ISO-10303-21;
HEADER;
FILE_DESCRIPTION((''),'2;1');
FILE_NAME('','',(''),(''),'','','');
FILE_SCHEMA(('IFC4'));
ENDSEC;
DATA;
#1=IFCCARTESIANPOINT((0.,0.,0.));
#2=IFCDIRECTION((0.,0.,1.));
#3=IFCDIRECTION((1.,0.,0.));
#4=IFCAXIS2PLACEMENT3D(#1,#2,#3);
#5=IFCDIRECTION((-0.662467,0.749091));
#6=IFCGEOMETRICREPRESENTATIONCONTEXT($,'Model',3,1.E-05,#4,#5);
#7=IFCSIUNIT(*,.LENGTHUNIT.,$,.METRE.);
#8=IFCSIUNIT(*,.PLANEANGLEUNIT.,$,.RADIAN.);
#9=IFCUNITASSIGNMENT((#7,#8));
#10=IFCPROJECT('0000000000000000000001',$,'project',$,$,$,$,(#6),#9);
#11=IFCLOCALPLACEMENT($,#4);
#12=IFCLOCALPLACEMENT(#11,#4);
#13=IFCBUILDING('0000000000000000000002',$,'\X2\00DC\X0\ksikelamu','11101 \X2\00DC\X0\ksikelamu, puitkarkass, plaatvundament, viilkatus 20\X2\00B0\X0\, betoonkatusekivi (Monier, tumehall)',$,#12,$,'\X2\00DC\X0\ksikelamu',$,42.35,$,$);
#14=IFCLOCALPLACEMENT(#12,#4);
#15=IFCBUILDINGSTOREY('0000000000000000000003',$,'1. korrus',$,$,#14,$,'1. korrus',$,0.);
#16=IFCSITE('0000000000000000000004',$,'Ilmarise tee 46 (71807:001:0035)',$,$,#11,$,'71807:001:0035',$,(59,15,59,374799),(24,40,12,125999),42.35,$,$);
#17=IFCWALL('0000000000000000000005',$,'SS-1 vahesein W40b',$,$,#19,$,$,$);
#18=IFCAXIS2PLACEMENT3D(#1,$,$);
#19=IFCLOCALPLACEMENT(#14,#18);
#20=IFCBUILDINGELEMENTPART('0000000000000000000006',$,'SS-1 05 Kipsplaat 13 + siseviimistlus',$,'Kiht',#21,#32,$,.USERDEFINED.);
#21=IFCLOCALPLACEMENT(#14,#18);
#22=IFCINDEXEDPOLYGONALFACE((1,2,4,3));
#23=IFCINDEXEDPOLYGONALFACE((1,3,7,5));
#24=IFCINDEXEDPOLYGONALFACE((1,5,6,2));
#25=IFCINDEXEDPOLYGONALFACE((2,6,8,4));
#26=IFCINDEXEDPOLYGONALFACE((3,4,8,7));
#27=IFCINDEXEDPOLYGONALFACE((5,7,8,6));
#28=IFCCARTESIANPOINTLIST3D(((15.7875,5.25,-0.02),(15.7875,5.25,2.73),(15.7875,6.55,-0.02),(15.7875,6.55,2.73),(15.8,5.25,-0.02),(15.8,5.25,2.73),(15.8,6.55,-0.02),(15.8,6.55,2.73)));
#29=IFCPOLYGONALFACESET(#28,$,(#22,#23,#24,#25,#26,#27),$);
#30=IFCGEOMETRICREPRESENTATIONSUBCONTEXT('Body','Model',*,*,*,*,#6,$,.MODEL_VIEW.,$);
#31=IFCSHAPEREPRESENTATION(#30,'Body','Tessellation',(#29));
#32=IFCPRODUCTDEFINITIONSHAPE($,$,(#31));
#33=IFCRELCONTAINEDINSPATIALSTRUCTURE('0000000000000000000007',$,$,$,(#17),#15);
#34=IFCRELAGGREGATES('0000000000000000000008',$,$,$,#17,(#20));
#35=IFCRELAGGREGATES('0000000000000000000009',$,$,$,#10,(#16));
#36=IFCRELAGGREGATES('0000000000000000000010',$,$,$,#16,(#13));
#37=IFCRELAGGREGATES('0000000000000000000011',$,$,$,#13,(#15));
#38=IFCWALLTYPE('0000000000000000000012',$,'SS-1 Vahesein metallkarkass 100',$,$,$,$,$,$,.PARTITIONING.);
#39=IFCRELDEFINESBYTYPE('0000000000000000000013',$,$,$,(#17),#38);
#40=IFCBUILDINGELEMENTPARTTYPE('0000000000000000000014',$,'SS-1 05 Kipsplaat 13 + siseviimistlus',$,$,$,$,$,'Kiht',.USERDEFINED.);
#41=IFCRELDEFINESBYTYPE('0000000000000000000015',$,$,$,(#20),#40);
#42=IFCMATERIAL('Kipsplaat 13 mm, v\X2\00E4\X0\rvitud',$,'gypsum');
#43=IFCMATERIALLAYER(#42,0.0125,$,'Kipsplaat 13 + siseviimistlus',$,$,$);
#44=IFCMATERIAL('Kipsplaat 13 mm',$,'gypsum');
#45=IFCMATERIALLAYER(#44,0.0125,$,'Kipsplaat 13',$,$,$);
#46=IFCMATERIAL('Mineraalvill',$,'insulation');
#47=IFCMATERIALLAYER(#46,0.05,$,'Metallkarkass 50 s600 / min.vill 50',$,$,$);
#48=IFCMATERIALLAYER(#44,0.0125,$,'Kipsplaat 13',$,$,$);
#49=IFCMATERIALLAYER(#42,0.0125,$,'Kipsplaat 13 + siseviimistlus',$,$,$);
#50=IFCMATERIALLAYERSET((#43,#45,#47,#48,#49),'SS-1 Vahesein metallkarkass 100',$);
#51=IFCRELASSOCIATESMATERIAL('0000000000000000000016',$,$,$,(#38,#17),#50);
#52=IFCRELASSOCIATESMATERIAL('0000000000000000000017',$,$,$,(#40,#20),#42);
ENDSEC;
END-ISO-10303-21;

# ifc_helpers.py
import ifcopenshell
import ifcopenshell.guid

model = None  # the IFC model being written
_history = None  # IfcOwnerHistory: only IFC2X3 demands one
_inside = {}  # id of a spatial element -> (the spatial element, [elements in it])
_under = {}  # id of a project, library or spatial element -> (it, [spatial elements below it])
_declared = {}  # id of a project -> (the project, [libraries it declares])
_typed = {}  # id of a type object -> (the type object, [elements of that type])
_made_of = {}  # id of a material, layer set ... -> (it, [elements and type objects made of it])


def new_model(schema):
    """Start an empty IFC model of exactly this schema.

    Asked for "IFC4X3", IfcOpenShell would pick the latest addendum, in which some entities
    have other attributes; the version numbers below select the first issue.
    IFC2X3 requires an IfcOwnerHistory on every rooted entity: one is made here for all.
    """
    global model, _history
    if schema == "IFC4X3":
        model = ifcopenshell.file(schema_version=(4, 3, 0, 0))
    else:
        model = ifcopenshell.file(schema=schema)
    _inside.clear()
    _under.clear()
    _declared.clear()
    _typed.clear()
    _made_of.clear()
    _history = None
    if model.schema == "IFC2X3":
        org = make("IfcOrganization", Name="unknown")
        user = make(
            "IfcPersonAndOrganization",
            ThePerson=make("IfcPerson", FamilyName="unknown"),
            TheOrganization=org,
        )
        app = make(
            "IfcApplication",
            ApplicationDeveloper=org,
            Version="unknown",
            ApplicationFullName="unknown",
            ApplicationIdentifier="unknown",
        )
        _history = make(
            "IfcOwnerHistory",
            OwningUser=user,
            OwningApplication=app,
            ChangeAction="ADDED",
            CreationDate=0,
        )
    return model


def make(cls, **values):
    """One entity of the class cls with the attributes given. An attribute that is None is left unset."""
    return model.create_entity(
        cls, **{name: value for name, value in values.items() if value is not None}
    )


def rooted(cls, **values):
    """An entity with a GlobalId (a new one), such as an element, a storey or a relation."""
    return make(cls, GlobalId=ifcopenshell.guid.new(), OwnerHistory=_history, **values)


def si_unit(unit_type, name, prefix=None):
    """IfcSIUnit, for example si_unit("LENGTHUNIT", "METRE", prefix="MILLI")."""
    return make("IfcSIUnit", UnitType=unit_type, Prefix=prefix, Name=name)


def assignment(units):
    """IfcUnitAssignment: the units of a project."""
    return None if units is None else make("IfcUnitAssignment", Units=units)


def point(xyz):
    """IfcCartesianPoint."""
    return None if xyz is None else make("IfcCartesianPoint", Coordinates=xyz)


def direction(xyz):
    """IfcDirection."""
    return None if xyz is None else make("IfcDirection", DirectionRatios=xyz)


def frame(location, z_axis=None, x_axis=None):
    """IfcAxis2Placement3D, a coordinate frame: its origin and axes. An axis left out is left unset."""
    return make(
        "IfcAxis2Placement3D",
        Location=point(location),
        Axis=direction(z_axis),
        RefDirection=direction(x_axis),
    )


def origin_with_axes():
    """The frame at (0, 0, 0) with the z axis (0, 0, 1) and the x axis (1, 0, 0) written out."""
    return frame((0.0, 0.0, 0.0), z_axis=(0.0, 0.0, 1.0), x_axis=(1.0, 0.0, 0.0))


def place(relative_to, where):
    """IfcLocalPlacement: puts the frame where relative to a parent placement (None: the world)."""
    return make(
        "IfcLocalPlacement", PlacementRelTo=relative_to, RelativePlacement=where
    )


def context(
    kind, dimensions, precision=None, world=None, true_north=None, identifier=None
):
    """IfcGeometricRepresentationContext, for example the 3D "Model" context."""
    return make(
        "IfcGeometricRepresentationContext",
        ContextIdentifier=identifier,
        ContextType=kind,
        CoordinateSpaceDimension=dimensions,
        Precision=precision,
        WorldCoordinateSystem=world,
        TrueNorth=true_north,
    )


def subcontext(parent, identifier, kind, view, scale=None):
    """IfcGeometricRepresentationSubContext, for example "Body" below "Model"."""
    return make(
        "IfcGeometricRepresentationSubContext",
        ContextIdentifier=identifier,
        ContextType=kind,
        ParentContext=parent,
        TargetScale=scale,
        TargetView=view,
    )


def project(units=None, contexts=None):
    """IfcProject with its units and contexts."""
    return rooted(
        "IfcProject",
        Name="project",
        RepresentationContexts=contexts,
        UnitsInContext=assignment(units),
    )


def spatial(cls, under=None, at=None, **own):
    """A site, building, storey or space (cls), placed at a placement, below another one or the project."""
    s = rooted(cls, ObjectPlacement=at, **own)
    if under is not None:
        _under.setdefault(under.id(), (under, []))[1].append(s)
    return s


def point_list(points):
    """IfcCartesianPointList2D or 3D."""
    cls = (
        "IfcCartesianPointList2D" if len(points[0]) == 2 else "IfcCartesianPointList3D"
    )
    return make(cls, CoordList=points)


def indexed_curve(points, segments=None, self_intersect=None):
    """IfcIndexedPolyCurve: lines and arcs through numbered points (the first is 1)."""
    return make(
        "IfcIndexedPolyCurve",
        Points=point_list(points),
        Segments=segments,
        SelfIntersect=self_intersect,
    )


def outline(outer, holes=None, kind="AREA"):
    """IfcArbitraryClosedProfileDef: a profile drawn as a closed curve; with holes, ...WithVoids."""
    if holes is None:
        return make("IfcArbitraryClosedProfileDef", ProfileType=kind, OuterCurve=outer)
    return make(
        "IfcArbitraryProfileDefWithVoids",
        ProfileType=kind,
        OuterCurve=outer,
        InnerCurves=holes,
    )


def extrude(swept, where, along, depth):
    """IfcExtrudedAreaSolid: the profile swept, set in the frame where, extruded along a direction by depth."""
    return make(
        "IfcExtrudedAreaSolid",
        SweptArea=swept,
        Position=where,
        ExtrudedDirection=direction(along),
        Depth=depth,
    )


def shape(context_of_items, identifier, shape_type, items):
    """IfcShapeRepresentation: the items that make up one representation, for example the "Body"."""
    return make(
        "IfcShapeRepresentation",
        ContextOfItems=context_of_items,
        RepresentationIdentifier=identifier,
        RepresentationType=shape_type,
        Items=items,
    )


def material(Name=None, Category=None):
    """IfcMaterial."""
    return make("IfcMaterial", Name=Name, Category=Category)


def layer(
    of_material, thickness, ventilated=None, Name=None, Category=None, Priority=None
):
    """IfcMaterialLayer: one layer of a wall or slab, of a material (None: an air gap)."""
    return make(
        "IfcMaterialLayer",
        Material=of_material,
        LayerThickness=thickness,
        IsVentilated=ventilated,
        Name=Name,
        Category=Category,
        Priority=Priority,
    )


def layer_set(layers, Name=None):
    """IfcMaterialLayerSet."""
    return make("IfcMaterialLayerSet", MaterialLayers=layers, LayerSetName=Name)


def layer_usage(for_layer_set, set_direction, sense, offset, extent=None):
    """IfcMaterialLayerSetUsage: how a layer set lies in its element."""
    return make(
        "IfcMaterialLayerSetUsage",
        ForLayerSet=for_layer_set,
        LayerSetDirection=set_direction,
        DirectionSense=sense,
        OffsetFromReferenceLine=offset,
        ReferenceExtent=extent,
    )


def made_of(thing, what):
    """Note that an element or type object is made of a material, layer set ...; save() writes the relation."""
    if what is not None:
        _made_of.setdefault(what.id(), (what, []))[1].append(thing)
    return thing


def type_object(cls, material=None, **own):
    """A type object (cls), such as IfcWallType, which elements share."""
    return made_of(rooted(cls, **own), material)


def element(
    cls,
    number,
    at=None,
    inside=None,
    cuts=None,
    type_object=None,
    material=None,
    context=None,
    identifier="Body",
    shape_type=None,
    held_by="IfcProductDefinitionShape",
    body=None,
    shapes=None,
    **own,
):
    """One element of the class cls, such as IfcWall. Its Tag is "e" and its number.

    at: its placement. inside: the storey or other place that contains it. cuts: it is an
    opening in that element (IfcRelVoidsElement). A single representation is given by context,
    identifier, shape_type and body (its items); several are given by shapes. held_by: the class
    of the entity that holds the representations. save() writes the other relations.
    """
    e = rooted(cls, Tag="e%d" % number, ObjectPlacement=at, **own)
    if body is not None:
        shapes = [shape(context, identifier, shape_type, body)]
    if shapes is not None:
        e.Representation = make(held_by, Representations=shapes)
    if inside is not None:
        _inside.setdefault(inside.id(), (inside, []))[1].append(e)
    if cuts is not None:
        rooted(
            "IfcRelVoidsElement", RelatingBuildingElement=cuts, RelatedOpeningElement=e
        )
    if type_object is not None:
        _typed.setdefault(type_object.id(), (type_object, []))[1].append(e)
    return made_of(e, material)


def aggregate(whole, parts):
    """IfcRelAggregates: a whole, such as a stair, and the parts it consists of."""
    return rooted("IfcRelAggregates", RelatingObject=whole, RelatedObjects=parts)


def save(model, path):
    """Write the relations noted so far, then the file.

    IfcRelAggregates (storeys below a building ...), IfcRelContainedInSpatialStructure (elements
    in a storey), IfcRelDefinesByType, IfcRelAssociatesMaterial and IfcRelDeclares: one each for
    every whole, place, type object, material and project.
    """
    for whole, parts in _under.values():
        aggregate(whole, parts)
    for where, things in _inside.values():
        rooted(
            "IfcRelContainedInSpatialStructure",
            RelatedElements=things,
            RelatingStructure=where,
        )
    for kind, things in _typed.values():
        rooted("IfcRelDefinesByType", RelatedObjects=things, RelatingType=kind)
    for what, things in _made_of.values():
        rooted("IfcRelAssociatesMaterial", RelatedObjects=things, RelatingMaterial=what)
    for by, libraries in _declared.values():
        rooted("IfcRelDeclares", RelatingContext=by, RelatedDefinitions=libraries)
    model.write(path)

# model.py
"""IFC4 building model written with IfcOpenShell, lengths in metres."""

from ifc_helpers import new_model, si_unit, direction, frame, origin_with_axes, place, context, subcontext, project, spatial, indexed_curve, outline, extrude, material, layer, layer_set, layer_usage, type_object, element, aggregate, save


model = new_model("IFC4")

# Units and contexts
model_context = context("Model", 3, precision=1e-05, world=origin_with_axes(), true_north=direction((-0.662467, 0.749091)))
body_context = subcontext(model_context, "Body", "Model", "MODEL_VIEW")
ifc_project = project(units=[si_unit("LENGTHUNIT", "METRE"), si_unit("PLANEANGLEUNIT", "RADIAN")], contexts=[model_context])

# Site, building, storey
site_placement = place(None, origin_with_axes())
site = spatial("IfcSite", under=ifc_project, at=site_placement, Name="Ilmarise tee 46 (71807:001:0035)", LongName="71807:001:0035", RefLatitude=(59, 15, 59, 374799), RefLongitude=(24, 40, 12, 125999), RefElevation=42.35)
building_placement = place(site_placement, origin_with_axes())
building = spatial("IfcBuilding", under=site, at=building_placement, Name="Üksikelamu", Description="11101 Üksikelamu, puitkarkass, plaatvundament, viilkatus 20°, betoonkatusekivi (Monier, tumehall)", LongName="Üksikelamu", ElevationOfRefHeight=42.35)
storey_placement = place(building_placement, origin_with_axes())
storey = spatial("IfcBuildingStorey", under=building, at=storey_placement, Name="1. korrus", LongName="1. korrus", Elevation=0.0)

# Wall
ifc_material_1 = material(Name="Kipsplaat 13 mm, värvitud", Category="gypsum")
ifc_layer_1 = layer(ifc_material_1, 0.0125, Name="Kipsplaat 13 + siseviimistlus")
ifc_material_2 = material(Name="Kipsplaat 13 mm", Category="gypsum")
ifc_layer_2 = layer(ifc_material_2, 0.0125, Name="Kipsplaat 13")
ifc_material_3 = material(Name="Mineraalvill", Category="insulation")
ifc_layer_3 = layer(ifc_material_3, 0.05, Name="Metallkarkass 50 s600 / min.vill 50")
ifc_layer_4 = layer(ifc_material_2, 0.0125, Name="Kipsplaat 13")
ifc_layer_5 = layer(ifc_material_1, 0.0125, Name="Kipsplaat 13 + siseviimistlus")
ifc_layer_set = layer_set([ifc_layer_1, ifc_layer_2, ifc_layer_3, ifc_layer_4, ifc_layer_5], Name="SS-1 Vahesein metallkarkass 100")
ifc_layer_usage = layer_usage(ifc_layer_set, "AXIS2", "NEGATIVE", 0.0)
wall_type = type_object("IfcWallType", Name="SS-1 Vahesein metallkarkass 100", PredefinedType="PARTITIONING", material=ifc_layer_set)
wall_placement = place(storey_placement, frame((15.7, 5.25, 0.0), z_axis=(0.0, 0.0, 1.0), x_axis=(0.0, 1.0, 0.0)))
wall = element("IfcWall", 1, at=wall_placement, inside=storey, type_object=wall_type, material=ifc_layer_usage, Name="SS-1 vahesein W40b")

# Building element part
building_element_part_type_1 = type_object("IfcBuildingElementPartType", Name="SS-1 05 Kipsplaat 13 + siseviimistlus", ElementType="Kiht", PredefinedType="USERDEFINED", material=ifc_material_1)
building_element_part_1_placement = place(wall_placement, origin_with_axes())
building_element_part_1 = element("IfcBuildingElementPart", 2, at=building_element_part_1_placement, type_object=building_element_part_type_1, material=ifc_material_1, Name="SS-1 05 Kipsplaat 13 + siseviimistlus", ObjectType="Kiht", PredefinedType="USERDEFINED", context=body_context, shape_type="SweptSolid", body=[
    extrude(outline(indexed_curve([(1.3, -0.02), (1.3, 2.73), (0.0, 2.73), (0.0, -0.02), (1.3, -0.02)], self_intersect=False)), frame((0.0, -0.0875, 0.0), z_axis=(0.0, -1.0, 0.0), x_axis=(1.0, 0.0, 0.0)), (0.0, 0.0, 1.0), 0.0125),
])
aggregate(wall, [building_element_part_1])

save(model, "model.ifc")
